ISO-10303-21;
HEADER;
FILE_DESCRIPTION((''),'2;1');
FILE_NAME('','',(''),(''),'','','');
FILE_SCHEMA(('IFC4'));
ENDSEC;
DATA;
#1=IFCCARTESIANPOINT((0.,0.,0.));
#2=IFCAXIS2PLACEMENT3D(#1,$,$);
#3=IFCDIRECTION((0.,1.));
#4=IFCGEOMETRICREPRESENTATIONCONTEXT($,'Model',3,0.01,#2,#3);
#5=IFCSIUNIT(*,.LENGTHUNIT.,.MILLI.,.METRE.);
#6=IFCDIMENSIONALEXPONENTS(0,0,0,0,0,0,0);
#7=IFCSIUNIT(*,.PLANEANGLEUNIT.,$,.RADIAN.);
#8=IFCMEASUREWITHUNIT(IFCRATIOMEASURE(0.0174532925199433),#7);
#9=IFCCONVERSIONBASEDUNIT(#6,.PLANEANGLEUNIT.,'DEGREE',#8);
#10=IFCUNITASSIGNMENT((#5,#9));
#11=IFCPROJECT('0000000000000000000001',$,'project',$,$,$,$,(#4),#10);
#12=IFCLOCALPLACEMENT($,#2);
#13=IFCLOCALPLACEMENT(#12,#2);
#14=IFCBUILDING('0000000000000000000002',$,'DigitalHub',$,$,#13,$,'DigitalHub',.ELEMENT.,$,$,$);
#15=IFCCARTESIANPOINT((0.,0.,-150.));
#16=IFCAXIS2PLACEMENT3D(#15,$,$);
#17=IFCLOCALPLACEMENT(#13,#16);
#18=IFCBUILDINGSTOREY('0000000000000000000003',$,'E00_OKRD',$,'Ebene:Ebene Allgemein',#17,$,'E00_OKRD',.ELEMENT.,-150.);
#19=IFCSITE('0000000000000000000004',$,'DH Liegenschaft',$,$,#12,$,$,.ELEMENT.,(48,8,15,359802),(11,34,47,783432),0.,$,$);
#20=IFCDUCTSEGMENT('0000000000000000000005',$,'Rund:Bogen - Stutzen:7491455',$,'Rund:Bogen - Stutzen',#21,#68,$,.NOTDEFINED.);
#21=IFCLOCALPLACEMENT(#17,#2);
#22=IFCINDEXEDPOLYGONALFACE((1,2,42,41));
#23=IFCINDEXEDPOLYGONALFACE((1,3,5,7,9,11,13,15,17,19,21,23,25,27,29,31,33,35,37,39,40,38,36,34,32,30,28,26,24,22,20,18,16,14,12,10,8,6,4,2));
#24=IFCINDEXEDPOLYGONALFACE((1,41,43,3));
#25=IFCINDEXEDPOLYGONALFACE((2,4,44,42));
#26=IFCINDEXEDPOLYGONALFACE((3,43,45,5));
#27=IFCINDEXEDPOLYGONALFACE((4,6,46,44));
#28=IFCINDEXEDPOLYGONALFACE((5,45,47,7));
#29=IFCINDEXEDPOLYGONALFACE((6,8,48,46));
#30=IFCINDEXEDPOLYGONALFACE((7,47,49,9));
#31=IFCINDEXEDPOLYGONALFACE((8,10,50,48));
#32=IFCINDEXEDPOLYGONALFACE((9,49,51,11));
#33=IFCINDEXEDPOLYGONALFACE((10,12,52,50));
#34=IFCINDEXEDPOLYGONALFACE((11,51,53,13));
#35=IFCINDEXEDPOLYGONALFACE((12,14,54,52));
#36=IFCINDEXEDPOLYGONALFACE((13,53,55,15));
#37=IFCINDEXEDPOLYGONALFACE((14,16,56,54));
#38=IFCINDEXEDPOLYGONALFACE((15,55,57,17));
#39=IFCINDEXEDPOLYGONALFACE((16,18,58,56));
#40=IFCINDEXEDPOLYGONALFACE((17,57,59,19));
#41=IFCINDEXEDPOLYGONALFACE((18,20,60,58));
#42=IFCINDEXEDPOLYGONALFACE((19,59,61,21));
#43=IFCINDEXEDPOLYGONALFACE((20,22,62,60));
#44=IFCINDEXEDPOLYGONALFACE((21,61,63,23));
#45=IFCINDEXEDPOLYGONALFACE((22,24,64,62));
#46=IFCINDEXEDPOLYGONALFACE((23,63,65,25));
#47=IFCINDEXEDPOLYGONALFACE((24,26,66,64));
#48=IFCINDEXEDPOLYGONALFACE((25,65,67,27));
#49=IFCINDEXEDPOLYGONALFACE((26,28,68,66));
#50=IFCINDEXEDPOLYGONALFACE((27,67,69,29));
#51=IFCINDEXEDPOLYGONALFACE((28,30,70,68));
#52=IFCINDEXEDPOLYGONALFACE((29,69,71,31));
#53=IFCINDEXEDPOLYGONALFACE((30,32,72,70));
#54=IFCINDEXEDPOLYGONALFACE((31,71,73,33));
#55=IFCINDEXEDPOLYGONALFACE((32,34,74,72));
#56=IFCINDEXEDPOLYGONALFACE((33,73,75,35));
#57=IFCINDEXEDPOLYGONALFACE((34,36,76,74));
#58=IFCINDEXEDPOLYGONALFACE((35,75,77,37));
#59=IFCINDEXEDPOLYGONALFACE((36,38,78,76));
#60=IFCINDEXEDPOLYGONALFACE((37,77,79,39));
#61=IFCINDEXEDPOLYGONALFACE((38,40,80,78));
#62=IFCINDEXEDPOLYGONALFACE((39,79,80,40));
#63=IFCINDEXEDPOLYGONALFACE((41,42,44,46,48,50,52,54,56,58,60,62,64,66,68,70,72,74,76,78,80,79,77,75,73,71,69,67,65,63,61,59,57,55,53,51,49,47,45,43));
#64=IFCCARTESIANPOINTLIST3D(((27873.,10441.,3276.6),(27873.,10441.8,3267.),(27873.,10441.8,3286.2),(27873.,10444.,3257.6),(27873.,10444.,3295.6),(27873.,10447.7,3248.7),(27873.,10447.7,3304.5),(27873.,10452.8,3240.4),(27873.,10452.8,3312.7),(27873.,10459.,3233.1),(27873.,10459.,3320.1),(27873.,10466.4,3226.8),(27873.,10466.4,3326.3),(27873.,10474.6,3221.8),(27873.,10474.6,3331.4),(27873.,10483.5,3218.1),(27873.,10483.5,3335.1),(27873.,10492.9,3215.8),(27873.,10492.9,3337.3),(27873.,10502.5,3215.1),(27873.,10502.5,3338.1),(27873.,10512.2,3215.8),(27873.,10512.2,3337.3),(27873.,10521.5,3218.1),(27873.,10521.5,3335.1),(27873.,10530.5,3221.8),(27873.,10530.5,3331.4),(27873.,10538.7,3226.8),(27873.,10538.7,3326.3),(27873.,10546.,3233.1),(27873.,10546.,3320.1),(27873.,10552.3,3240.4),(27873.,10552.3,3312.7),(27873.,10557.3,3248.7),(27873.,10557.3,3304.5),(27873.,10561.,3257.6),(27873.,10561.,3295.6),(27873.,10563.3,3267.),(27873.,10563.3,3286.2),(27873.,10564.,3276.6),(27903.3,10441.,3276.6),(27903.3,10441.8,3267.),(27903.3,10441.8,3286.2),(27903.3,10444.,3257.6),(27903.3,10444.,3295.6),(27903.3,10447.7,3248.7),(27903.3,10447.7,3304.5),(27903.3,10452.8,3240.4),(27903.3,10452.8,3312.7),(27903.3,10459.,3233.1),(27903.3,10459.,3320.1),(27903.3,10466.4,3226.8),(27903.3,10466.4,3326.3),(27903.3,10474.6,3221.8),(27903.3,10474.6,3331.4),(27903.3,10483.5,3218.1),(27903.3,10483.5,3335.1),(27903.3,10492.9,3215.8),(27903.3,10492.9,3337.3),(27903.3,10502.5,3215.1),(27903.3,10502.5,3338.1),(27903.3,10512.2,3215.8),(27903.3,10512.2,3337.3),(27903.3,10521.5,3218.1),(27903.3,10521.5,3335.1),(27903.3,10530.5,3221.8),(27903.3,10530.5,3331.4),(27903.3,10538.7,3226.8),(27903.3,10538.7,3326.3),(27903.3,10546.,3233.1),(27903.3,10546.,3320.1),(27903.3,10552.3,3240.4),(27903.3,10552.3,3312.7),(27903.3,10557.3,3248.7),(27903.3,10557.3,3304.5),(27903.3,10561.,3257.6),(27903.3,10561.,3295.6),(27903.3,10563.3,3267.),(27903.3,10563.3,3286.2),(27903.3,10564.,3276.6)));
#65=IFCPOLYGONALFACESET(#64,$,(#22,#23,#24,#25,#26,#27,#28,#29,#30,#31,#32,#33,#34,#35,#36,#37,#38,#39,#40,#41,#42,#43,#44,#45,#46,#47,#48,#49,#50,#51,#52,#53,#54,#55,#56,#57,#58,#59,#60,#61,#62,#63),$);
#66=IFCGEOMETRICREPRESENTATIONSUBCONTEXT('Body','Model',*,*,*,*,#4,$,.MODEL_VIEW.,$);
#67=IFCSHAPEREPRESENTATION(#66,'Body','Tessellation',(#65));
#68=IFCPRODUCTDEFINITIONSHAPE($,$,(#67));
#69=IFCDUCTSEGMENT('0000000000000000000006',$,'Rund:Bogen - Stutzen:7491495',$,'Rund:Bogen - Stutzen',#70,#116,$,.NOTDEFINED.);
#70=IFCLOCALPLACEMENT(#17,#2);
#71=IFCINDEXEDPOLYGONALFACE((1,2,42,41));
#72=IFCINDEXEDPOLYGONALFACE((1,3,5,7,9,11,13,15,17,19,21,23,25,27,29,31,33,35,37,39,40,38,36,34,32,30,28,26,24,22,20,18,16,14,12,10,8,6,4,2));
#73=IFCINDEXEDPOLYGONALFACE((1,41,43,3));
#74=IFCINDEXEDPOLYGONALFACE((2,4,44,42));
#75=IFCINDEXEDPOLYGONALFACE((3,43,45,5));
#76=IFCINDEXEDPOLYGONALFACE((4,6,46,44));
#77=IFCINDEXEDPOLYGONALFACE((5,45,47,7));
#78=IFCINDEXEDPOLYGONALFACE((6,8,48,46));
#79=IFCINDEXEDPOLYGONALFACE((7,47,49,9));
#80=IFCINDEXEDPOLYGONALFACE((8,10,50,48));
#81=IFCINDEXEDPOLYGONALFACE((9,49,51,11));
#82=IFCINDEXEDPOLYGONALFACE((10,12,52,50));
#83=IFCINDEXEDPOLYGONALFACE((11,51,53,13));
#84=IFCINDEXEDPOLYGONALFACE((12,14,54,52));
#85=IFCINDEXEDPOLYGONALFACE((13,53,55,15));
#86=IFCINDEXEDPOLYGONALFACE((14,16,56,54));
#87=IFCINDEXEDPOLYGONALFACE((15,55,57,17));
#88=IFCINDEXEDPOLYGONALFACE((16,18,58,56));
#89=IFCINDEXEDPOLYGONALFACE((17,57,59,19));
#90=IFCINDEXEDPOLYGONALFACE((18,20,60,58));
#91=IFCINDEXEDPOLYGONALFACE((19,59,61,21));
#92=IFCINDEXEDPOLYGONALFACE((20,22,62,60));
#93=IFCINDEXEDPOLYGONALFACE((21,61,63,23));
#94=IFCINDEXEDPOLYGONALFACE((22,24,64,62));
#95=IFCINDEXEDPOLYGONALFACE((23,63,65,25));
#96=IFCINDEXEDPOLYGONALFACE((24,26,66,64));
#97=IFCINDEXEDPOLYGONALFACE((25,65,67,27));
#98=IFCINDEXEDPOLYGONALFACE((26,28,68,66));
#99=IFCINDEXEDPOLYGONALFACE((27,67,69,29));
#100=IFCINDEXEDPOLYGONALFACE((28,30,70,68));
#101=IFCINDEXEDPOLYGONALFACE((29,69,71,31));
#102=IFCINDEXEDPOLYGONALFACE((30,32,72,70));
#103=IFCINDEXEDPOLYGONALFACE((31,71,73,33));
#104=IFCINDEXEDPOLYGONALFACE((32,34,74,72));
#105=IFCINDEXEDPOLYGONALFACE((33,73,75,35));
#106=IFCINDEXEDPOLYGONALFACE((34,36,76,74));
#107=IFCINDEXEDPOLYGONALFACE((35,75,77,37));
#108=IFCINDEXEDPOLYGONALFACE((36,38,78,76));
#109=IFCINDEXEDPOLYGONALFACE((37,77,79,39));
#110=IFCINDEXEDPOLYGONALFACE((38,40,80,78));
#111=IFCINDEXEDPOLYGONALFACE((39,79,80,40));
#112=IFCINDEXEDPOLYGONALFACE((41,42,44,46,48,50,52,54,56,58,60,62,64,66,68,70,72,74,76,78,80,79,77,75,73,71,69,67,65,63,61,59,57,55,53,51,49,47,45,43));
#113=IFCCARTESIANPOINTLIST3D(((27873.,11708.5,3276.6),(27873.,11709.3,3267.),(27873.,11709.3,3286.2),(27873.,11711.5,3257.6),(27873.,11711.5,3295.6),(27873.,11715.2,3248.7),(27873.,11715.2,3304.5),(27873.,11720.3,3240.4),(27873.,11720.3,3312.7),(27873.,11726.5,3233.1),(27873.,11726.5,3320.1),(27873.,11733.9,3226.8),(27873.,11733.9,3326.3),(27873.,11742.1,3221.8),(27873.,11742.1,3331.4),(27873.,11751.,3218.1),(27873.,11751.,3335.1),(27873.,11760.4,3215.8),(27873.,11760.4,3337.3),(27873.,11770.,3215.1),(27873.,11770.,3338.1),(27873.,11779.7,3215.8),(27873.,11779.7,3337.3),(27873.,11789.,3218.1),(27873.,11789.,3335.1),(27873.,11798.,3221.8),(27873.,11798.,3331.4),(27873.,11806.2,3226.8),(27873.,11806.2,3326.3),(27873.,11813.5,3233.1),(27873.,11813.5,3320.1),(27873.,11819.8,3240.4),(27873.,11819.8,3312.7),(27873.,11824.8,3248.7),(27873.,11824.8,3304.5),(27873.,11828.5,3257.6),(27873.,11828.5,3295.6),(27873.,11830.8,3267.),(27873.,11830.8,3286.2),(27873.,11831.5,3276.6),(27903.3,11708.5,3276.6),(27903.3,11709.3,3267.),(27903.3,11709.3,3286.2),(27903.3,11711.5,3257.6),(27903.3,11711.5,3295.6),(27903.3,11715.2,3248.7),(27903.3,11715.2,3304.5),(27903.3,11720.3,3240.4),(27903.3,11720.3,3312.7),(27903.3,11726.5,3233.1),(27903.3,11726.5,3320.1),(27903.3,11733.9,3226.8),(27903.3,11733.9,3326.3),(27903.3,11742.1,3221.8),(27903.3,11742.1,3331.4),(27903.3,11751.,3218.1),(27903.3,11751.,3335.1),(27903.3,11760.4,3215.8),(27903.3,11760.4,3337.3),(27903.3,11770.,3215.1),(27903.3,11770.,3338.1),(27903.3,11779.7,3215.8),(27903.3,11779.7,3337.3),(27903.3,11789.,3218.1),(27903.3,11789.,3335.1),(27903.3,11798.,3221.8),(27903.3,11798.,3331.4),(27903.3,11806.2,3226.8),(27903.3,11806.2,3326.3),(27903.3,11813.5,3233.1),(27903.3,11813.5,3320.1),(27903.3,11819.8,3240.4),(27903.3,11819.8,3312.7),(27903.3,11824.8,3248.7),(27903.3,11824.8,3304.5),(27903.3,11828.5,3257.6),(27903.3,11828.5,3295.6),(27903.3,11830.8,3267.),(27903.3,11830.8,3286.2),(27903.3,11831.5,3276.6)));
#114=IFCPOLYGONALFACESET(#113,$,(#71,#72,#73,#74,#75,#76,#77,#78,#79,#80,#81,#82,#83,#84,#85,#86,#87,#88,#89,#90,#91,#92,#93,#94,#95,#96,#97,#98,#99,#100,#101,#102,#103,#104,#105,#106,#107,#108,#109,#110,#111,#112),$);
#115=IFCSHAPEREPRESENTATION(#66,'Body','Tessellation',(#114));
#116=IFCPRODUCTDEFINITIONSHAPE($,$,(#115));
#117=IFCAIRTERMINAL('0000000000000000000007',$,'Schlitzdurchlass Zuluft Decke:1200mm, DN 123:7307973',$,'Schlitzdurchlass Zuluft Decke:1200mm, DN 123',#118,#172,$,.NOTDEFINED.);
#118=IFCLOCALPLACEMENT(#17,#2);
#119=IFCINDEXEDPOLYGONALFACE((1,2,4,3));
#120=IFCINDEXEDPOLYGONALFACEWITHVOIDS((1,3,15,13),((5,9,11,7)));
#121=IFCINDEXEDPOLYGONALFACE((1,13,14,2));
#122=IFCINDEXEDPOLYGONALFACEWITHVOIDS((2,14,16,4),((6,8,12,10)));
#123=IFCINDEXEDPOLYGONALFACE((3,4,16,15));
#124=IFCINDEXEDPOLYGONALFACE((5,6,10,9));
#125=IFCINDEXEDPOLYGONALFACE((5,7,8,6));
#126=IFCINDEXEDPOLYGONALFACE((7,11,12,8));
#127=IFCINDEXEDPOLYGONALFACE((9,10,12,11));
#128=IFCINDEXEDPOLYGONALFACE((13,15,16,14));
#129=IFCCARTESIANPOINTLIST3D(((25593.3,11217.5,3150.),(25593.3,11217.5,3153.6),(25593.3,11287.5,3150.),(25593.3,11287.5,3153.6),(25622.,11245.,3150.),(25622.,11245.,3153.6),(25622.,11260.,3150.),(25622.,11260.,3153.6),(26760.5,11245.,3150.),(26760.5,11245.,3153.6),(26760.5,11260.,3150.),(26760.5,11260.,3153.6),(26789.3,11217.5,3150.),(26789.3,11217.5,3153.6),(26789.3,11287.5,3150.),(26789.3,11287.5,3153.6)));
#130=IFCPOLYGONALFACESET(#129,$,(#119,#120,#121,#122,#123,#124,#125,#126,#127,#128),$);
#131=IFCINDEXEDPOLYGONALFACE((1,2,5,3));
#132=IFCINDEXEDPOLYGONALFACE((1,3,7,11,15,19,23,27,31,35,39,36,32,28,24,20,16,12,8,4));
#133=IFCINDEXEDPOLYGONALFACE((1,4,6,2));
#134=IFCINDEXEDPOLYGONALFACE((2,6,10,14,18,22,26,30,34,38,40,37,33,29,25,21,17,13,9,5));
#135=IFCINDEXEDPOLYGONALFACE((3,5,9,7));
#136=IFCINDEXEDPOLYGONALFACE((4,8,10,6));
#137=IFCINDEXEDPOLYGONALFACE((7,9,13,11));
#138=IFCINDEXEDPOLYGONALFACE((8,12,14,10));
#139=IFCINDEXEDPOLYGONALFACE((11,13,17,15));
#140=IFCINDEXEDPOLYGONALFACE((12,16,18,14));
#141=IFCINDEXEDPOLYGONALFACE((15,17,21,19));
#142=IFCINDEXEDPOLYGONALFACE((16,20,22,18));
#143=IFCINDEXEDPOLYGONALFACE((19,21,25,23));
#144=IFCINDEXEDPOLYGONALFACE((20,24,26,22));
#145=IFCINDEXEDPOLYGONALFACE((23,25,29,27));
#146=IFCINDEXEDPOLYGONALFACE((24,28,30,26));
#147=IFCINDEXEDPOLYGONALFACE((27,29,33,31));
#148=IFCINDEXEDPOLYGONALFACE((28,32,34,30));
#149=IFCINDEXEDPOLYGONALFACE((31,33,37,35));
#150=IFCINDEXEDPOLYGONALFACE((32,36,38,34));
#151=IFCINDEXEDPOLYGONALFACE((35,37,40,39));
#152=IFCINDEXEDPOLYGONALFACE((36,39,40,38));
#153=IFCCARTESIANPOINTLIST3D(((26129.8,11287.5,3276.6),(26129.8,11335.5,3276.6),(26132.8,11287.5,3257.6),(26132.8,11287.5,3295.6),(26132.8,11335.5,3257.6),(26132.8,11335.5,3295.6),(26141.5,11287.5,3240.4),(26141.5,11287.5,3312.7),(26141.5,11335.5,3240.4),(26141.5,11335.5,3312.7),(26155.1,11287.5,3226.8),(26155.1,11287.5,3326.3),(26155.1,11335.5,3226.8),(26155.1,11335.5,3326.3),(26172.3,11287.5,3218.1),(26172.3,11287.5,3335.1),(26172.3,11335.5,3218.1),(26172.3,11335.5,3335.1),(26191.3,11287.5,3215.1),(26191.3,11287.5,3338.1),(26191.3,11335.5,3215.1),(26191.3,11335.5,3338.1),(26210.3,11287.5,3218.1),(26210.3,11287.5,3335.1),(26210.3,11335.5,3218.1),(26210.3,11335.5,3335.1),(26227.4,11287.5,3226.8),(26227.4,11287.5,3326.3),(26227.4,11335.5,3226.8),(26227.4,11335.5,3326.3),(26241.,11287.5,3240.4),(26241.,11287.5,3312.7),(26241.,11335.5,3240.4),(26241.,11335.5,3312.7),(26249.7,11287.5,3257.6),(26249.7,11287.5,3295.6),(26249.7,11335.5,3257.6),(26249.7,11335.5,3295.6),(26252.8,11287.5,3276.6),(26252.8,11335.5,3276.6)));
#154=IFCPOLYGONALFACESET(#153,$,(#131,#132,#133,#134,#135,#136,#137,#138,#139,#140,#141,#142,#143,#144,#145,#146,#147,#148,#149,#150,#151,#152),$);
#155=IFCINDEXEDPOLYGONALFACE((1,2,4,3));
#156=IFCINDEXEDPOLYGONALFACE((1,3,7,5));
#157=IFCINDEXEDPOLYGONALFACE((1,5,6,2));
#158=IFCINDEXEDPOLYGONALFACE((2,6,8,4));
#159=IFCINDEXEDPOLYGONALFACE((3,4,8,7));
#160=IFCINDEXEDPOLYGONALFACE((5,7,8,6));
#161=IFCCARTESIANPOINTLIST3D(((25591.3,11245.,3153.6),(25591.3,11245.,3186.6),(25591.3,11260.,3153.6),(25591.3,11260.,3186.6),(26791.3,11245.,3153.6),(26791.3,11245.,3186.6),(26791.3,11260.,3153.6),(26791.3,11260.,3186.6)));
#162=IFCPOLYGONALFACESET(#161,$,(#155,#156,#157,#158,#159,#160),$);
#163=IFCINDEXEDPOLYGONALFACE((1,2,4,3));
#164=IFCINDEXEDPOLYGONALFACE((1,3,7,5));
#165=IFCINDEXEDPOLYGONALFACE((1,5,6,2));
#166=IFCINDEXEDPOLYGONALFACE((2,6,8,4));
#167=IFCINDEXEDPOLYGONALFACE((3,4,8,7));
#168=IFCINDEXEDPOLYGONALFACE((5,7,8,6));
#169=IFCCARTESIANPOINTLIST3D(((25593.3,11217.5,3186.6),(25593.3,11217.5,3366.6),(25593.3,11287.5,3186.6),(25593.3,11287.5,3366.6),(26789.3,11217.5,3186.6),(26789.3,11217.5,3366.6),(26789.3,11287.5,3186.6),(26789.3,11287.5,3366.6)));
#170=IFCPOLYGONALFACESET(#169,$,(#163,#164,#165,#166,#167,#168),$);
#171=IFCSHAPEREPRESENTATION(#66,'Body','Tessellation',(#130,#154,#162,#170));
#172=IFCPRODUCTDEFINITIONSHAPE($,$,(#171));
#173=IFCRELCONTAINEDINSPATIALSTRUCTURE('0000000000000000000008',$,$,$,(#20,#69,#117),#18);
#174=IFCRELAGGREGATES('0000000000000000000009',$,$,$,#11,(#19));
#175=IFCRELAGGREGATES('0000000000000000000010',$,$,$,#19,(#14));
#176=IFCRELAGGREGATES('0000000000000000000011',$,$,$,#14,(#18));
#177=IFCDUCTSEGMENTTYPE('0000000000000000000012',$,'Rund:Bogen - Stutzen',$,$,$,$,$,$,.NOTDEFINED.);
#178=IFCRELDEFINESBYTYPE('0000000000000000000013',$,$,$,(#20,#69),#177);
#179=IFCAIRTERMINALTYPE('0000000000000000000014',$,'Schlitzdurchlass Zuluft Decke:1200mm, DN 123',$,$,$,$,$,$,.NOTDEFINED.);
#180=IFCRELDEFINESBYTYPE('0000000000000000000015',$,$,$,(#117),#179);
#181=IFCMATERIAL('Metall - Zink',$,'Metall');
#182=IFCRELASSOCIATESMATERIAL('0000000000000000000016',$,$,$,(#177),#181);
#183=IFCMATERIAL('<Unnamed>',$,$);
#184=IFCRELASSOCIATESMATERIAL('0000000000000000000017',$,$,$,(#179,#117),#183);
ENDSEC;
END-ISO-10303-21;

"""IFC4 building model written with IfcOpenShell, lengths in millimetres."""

from ifc_helpers import new_model, entity, si_unit, converted_unit, direction, frame, origin, place, context, subcontext, project, spatial, indexed_curve, outline, extrude, source, transform, mapped, material, type_object, type_shapes, element, save


model = new_model("IFC4")

# Units and contexts
model_context = context("Model", 3, precision=0.01, world=origin(), true_north=direction((0.0, 1.0)))
body_context = subcontext(model_context, "Body", "Model", "MODEL_VIEW")
ifc_project = project(units=[si_unit("LENGTHUNIT", "METRE", prefix="MILLI"), converted_unit("PLANEANGLEUNIT", "DEGREE", entity("IfcRatioMeasure", 0.0174532925199433), si_unit("PLANEANGLEUNIT", "RADIAN"), dimensions=[0, 0, 0, 0, 0, 0, 0])], contexts=[model_context])

# Site, building, storey
site_placement = place(None, origin())
site = spatial("IfcSite", under=ifc_project, at=site_placement, Name="DH Liegenschaft", CompositionType="ELEMENT", RefLatitude=(48, 8, 15, 359802), RefLongitude=(11, 34, 47, 783432), RefElevation=0.0)
building_placement = place(site_placement, origin())
building = spatial("IfcBuilding", under=site, at=building_placement, Name="DigitalHub", LongName="DigitalHub", CompositionType="ELEMENT")
storey_placement = place(building_placement, frame((0.0, 0.0, -150.0)))
storey = spatial("IfcBuildingStorey", under=building, at=storey_placement, Name="E00_OKRD", ObjectType="Ebene:Ebene Allgemein", LongName="E00_OKRD", CompositionType="ELEMENT", Elevation=-150.0)

# Duct segments
ifc_material_1 = material(Name="Metall - Zink", Category="Metall")
duct_segment_type_1 = type_object("IfcDuctSegmentType", Name="Rund:Bogen - Stutzen", PredefinedType="NOTDEFINED", material=ifc_material_1)
duct_segment_1_placement = place(storey_placement, frame((27873.0, 10439.4, 3213.5)))
element("IfcDuctSegment", 1, at=duct_segment_1_placement, inside=storey, type_object=duct_segment_type_1, Name="Rund:Bogen - Stutzen:7491455", ObjectType="Rund:Bogen - Stutzen", PredefinedType="NOTDEFINED", context=body_context, shape_type="SweptSolid", body=[
    extrude(outline(indexed_curve([(61.5, 0.0), (60.7, 9.6), (58.5, 19.0), (54.8, 27.9), (49.8, 36.1), (43.5, 43.5), (36.1, 49.8), (27.9, 54.8), (19.0, 58.5), (9.6, 60.7), (0.0, 61.5), (-9.6, 60.7), (-19.0, 58.5), (-27.9, 54.8), (-36.1, 49.8), (-43.5, 43.5), (-49.8, 36.1), (-54.8, 27.9), (-58.5, 19.0), (-60.7, 9.6), (-61.5, 0.0), (-60.7, -9.6), (-58.5, -19.0), (-54.8, -27.9), (-49.8, -36.1), (-43.5, -43.5), (-36.1, -49.8), (-27.9, -54.8), (-19.0, -58.5), (-9.6, -60.7), (0.0, -61.5), (9.6, -60.7), (19.0, -58.5), (27.9, -54.8), (36.1, -49.8), (43.5, -43.5), (49.8, -36.1), (54.8, -27.9), (58.5, -19.0), (60.7, -9.6), (61.5, 0.0)], self_intersect=False)), frame((0.0, 63.1, 63.1), z_axis=(1.0, 0.0, 0.0), x_axis=(0.0, -1.0, 0.0)), (0.0, 0.0, 1.0), 30.4),
])
duct_segment_2_placement = place(storey_placement, frame((27873.0, 11706.9, 3213.5)))
element("IfcDuctSegment", 2, at=duct_segment_2_placement, inside=storey, type_object=duct_segment_type_1, Name="Rund:Bogen - Stutzen:7491495", ObjectType="Rund:Bogen - Stutzen", PredefinedType="NOTDEFINED", context=body_context, shape_type="SweptSolid", body=[
    extrude(outline(indexed_curve([(61.5, 0.0), (60.7, 9.6), (58.5, 19.0), (54.8, 27.9), (49.8, 36.1), (43.5, 43.5), (36.1, 49.8), (27.9, 54.8), (19.0, 58.5), (9.6, 60.7), (0.0, 61.5), (-9.6, 60.7), (-19.0, 58.5), (-27.9, 54.8), (-36.1, 49.8), (-43.5, 43.5), (-49.8, 36.1), (-54.8, 27.9), (-58.5, 19.0), (-60.7, 9.6), (-61.5, 0.0), (-60.7, -9.6), (-58.5, -19.0), (-54.8, -27.9), (-49.8, -36.1), (-43.5, -43.5), (-36.1, -49.8), (-27.9, -54.8), (-19.0, -58.5), (-9.6, -60.7), (0.0, -61.5), (9.6, -60.7), (19.0, -58.5), (27.9, -54.8), (36.1, -49.8), (43.5, -43.5), (49.8, -36.1), (54.8, -27.9), (58.5, -19.0), (60.7, -9.6), (61.5, 0.0)], self_intersect=False)), frame((0.0, 63.1, 63.1), z_axis=(1.0, 0.0, 0.0), x_axis=(0.0, -1.0, 0.0)), (0.0, 0.0, 1.0), 30.4),
])

# Air terminal
ifc_material_2 = material(Name="<Unnamed>")
air_terminal_type_1 = type_object("IfcAirTerminalType", Name="Schlitzdurchlass Zuluft Decke:1200mm, DN 123", PredefinedType="NOTDEFINED", material=ifc_material_2)
shared_shape_1 = source(origin(), body_context, "Body", "SweptSolid", [
    extrude(outline(indexed_curve([(-598.0, -35.0), (598.0, -35.0), (598.0, 35.0), (-598.0, 35.0), (-598.0, -35.0)], self_intersect=False), holes=[indexed_curve([(-569.2, -7.5), (-569.2, 7.5), (569.2, 7.5), (569.2, -7.5), (-569.2, -7.5)], self_intersect=False)]), frame((600.0, 35.0, 0.0), z_axis=(0.0, 0.0, 1.0), x_axis=(-1.0, 0.0, 0.0)), (0.0, 0.0, 1.0), 3.6),
    extrude(outline(indexed_curve([(61.5, 0.0), (58.5, 19.0), (49.8, 36.1), (36.1, 49.8), (19.0, 58.5), (0.0, 61.5), (-19.0, 58.5), (-36.1, 49.8), (-49.8, 36.1), (-58.5, 19.0), (-61.5, 0.0), (-58.5, -19.0), (-49.8, -36.1), (-36.1, -49.8), (-19.0, -58.5), (0.0, -61.5), (19.0, -58.5), (36.1, -49.8), (49.8, -36.1), (58.5, -19.0), (61.5, 0.0)], self_intersect=False)), frame((600.0, 70.0, 126.6), z_axis=(0.0, 1.0, 0.0), x_axis=(-1.0, 0.0, 0.0)), (0.0, 0.0, 1.0), 48.0),
    extrude(outline(indexed_curve([(-600.0, -7.5), (600.0, -7.5), (600.0, 7.5), (-600.0, 7.5), (-600.0, -7.5)], self_intersect=False)), frame((600.0, 35.0, 3.6), z_axis=(0.0, 0.0, 1.0), x_axis=(-1.0, 0.0, 0.0)), (0.0, 0.0, 1.0), 33.0),
    extrude(outline(indexed_curve([(-598.0, -35.0), (598.0, -35.0), (598.0, 35.0), (-598.0, 35.0), (-598.0, -35.0)], self_intersect=False)), frame((600.0, 35.0, 36.6), z_axis=(0.0, 0.0, 1.0), x_axis=(-1.0, 0.0, 0.0)), (0.0, 0.0, 1.0), 180.0),
])
type_shapes(air_terminal_type_1, [shared_shape_1])
air_terminal_1_placement = place(storey_placement, frame((25591.3, 11217.5, 3150.0)))
element("IfcAirTerminal", 3, at=air_terminal_1_placement, inside=storey, type_object=air_terminal_type_1, material=ifc_material_2, Name="Schlitzdurchlass Zuluft Decke:1200mm, DN 123:7307973", ObjectType="Schlitzdurchlass Zuluft Decke:1200mm, DN 123", PredefinedType="NOTDEFINED", context=body_context, shape_type="MappedRepresentation", body=[
    mapped(shared_shape_1, transform((0.0, 0.0, 0.0), scale=1.0)),
])

save(model, "model.ifc")
